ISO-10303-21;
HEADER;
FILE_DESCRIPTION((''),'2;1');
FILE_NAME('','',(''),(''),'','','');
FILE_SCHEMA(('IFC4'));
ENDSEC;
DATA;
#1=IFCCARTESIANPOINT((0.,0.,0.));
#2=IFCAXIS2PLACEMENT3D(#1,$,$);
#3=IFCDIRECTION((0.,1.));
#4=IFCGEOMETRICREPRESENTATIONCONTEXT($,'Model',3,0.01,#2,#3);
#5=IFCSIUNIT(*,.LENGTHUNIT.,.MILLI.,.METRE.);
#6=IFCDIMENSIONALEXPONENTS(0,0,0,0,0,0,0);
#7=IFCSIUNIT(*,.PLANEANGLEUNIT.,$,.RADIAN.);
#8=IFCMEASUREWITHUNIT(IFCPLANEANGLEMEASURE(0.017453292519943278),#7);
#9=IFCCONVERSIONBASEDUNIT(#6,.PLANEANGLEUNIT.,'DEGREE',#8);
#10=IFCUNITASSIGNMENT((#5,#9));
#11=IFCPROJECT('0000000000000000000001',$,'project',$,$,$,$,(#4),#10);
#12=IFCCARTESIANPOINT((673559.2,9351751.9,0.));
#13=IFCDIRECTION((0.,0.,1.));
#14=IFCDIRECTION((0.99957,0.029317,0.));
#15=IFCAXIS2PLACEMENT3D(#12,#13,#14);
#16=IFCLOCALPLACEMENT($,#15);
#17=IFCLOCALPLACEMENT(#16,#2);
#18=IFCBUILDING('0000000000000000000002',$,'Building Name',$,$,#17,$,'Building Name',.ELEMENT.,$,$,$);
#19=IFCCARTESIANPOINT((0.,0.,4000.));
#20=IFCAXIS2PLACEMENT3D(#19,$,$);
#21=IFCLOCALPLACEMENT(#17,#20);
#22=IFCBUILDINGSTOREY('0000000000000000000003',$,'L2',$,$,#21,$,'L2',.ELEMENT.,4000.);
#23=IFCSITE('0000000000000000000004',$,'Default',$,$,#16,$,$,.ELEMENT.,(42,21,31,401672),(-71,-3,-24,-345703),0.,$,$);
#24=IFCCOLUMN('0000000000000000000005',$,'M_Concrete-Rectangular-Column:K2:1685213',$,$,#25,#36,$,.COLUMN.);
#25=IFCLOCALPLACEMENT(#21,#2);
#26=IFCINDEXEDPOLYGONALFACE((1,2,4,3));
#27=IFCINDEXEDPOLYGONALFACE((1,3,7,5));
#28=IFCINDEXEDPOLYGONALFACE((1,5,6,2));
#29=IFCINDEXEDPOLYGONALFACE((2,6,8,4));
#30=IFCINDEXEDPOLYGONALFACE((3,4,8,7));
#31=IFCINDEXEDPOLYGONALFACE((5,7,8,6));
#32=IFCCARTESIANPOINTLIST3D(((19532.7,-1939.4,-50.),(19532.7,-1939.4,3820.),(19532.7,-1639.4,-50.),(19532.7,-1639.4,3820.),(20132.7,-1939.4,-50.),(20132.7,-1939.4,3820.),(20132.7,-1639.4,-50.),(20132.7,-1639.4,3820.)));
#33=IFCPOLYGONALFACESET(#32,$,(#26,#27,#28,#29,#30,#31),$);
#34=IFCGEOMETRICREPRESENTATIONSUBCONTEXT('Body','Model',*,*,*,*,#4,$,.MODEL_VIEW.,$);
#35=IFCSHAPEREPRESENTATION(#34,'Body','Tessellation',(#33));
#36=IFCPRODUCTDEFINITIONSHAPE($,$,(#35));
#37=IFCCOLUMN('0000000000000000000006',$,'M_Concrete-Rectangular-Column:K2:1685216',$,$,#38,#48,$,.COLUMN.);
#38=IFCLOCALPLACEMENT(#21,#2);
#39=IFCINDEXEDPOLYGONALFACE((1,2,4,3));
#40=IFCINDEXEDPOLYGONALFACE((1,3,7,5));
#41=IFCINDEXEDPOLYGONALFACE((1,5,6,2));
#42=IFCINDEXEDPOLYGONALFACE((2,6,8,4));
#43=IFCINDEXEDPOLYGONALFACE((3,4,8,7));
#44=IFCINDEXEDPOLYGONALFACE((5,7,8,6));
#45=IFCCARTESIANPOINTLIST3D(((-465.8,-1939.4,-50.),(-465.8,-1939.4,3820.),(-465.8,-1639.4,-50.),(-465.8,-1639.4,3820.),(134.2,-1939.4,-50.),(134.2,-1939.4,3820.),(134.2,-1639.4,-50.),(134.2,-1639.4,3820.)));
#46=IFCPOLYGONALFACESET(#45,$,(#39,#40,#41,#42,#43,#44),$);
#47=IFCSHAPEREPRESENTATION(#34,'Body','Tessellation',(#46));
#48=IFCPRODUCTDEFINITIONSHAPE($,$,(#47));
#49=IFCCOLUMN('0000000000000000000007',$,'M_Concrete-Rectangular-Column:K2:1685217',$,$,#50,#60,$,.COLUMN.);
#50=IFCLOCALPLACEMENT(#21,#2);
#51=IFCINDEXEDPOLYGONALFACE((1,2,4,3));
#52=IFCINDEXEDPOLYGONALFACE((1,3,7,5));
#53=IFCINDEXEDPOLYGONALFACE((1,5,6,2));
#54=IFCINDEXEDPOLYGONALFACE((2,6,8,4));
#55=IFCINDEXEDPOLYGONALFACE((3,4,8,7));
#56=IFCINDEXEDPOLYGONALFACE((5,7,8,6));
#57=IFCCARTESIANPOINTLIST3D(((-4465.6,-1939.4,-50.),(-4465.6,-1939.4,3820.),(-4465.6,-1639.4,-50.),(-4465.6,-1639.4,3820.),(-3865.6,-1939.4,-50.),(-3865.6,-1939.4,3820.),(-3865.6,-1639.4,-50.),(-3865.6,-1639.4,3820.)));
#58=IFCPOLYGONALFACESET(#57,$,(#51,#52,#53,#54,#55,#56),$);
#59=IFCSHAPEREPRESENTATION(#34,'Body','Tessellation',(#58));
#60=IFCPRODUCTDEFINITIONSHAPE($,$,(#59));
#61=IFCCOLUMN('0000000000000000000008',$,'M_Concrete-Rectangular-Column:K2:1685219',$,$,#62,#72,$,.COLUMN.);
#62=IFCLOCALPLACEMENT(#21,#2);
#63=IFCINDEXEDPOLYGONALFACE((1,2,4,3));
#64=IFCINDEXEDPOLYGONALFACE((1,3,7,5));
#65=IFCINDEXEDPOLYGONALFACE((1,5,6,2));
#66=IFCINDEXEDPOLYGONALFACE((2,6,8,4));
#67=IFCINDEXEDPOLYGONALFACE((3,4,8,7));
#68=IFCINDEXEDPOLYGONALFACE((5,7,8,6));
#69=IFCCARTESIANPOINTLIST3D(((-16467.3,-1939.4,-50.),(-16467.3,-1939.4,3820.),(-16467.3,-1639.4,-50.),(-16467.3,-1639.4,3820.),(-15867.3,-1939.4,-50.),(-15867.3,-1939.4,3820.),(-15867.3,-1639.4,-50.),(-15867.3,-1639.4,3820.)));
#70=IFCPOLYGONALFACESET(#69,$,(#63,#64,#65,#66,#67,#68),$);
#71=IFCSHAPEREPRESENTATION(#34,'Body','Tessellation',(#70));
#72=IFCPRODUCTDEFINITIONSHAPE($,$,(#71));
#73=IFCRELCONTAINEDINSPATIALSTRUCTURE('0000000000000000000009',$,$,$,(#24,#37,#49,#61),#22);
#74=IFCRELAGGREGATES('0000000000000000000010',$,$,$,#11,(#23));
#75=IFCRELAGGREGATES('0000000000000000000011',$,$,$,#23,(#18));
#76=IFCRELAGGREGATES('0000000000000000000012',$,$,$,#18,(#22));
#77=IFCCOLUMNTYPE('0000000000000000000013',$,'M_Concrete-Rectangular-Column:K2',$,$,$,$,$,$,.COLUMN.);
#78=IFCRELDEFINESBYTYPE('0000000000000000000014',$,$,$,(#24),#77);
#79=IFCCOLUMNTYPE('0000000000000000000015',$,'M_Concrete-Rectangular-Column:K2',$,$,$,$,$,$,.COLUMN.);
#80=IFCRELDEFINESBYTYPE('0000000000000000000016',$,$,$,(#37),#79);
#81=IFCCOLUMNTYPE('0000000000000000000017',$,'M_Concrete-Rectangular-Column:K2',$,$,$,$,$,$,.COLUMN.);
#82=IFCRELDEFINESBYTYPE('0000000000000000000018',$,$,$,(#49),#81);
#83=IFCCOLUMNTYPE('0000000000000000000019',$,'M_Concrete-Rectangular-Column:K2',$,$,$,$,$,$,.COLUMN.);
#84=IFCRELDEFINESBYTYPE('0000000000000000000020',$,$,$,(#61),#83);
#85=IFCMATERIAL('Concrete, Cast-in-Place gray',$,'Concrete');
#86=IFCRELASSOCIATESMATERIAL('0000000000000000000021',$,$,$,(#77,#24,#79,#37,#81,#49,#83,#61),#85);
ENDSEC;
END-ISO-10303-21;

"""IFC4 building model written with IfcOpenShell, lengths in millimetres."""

from ifc_helpers import new_model, entity, si_unit, converted_unit, direction, frame, origin, place, context, subcontext, project, spatial, indexed_curve, outline, extrude, source, transform, mapped, material, type_object, type_shapes, element, save


model = new_model("IFC4")

# Units and contexts
model_context = context("Model", 3, precision=0.01, world=origin(), true_north=direction((0.0, 1.0)))
body_context = subcontext(model_context, "Body", "Model", "MODEL_VIEW")
ifc_project = project(units=[si_unit("LENGTHUNIT", "METRE", prefix="MILLI"), converted_unit("PLANEANGLEUNIT", "DEGREE", entity("IfcPlaneAngleMeasure", 0.017453292519943278), si_unit("PLANEANGLEUNIT", "RADIAN"), dimensions=[0, 0, 0, 0, 0, 0, 0])], contexts=[model_context])

# Site, building, storey
site_placement = place(None, frame((673559.2, 9351751.9, 0.0), z_axis=(0.0, 0.0, 1.0), x_axis=(0.99957, 0.029317, 0.0)))
site = spatial("IfcSite", under=ifc_project, at=site_placement, Name="Default", CompositionType="ELEMENT", RefLatitude=(42, 21, 31, 401672), RefLongitude=(-71, -3, -24, -345703), RefElevation=0.0)
building_placement = place(site_placement, origin())
building = spatial("IfcBuilding", under=site, at=building_placement, Name="Building Name", LongName="Building Name", CompositionType="ELEMENT")
storey_placement = place(building_placement, frame((0.0, 0.0, 4000.0)))
storey = spatial("IfcBuildingStorey", under=building, at=storey_placement, Name="L2", LongName="L2", CompositionType="ELEMENT", Elevation=4000.0)

# Columns
ifc_material = material(Name="Concrete, Cast-in-Place gray", Category="Concrete")
column_type_1 = type_object("IfcColumnType", Name="M_Concrete-Rectangular-Column:K2", PredefinedType="COLUMN", material=ifc_material)
shared_shape_1 = source(origin(), body_context, "Body", "SweptSolid", [
    extrude(outline(indexed_curve([(-150.0, -300.0), (150.0, -300.0), (150.0, 300.0), (-150.0, 300.0), (-150.0, -300.0)], self_intersect=False)), frame((19832.7, -1789.4, 3950.0), z_axis=(0.0, 0.0, 1.0), x_axis=(0.0, -1.0, 0.0)), (0.0, 0.0, 1.0), 3870.0),
])
type_shapes(column_type_1, [shared_shape_1])
column_1_placement = place(storey_placement, frame((0.0, 0.0, -4000.0)))
element("IfcColumn", 1, at=column_1_placement, inside=storey, type_object=column_type_1, material=ifc_material, Name="M_Concrete-Rectangular-Column:K2:1685213", PredefinedType="COLUMN", context=body_context, shape_type="MappedRepresentation", body=[
    mapped(shared_shape_1, transform((0.0, 0.0, 0.0), scale=1.0)),
])
column_type_2 = type_object("IfcColumnType", Name="M_Concrete-Rectangular-Column:K2", PredefinedType="COLUMN", material=ifc_material)
shared_shape_2 = source(origin(), body_context, "Body", "SweptSolid", [
    extrude(outline(indexed_curve([(-150.0, -300.0), (150.0, -300.0), (150.0, 300.0), (-150.0, 300.0), (-150.0, -300.0)], self_intersect=False)), frame((-165.8, -1789.4, 3950.0), z_axis=(0.0, 0.0, 1.0), x_axis=(0.0, -1.0, 0.0)), (0.0, 0.0, 1.0), 3870.0),
])
type_shapes(column_type_2, [shared_shape_2])
column_2_placement = place(storey_placement, frame((0.0, 0.0, -4000.0)))
element("IfcColumn", 2, at=column_2_placement, inside=storey, type_object=column_type_2, material=ifc_material, Name="M_Concrete-Rectangular-Column:K2:1685216", PredefinedType="COLUMN", context=body_context, shape_type="MappedRepresentation", body=[
    mapped(shared_shape_2, transform((0.0, 0.0, 0.0), scale=1.0)),
])
column_type_3 = type_object("IfcColumnType", Name="M_Concrete-Rectangular-Column:K2", PredefinedType="COLUMN", material=ifc_material)
shared_shape_3 = source(origin(), body_context, "Body", "SweptSolid", [
    extrude(outline(indexed_curve([(-150.0, -300.0), (150.0, -300.0), (150.0, 300.0), (-150.0, 300.0), (-150.0, -300.0)], self_intersect=False)), frame((-4165.6, -1789.4, 3950.0), z_axis=(0.0, 0.0, 1.0), x_axis=(0.0, -1.0, 0.0)), (0.0, 0.0, 1.0), 3870.0),
])
type_shapes(column_type_3, [shared_shape_3])
column_3_placement = place(storey_placement, frame((0.0, 0.0, -4000.0)))
element("IfcColumn", 3, at=column_3_placement, inside=storey, type_object=column_type_3, material=ifc_material, Name="M_Concrete-Rectangular-Column:K2:1685217", PredefinedType="COLUMN", context=body_context, shape_type="MappedRepresentation", body=[
    mapped(shared_shape_3, transform((0.0, 0.0, 0.0), scale=1.0)),
])
column_type_4 = type_object("IfcColumnType", Name="M_Concrete-Rectangular-Column:K2", PredefinedType="COLUMN", material=ifc_material)
shared_shape_4 = source(origin(), body_context, "Body", "SweptSolid", [
    extrude(outline(indexed_curve([(-150.0, -300.0), (150.0, -300.0), (150.0, 300.0), (-150.0, 300.0), (-150.0, -300.0)], self_intersect=False)), frame((-16167.3, -1789.4, 3950.0), z_axis=(0.0, 0.0, 1.0), x_axis=(0.0, -1.0, 0.0)), (0.0, 0.0, 1.0), 3870.0),
])
type_shapes(column_type_4, [shared_shape_4])
column_4_placement = place(storey_placement, frame((0.0, 0.0, -4000.0)))
element("IfcColumn", 4, at=column_4_placement, inside=storey, type_object=column_type_4, material=ifc_material, Name="M_Concrete-Rectangular-Column:K2:1685219", PredefinedType="COLUMN", context=body_context, shape_type="MappedRepresentation", body=[
    mapped(shared_shape_4, transform((0.0, 0.0, 0.0), scale=1.0)),
])

save(model, "model.ifc")
